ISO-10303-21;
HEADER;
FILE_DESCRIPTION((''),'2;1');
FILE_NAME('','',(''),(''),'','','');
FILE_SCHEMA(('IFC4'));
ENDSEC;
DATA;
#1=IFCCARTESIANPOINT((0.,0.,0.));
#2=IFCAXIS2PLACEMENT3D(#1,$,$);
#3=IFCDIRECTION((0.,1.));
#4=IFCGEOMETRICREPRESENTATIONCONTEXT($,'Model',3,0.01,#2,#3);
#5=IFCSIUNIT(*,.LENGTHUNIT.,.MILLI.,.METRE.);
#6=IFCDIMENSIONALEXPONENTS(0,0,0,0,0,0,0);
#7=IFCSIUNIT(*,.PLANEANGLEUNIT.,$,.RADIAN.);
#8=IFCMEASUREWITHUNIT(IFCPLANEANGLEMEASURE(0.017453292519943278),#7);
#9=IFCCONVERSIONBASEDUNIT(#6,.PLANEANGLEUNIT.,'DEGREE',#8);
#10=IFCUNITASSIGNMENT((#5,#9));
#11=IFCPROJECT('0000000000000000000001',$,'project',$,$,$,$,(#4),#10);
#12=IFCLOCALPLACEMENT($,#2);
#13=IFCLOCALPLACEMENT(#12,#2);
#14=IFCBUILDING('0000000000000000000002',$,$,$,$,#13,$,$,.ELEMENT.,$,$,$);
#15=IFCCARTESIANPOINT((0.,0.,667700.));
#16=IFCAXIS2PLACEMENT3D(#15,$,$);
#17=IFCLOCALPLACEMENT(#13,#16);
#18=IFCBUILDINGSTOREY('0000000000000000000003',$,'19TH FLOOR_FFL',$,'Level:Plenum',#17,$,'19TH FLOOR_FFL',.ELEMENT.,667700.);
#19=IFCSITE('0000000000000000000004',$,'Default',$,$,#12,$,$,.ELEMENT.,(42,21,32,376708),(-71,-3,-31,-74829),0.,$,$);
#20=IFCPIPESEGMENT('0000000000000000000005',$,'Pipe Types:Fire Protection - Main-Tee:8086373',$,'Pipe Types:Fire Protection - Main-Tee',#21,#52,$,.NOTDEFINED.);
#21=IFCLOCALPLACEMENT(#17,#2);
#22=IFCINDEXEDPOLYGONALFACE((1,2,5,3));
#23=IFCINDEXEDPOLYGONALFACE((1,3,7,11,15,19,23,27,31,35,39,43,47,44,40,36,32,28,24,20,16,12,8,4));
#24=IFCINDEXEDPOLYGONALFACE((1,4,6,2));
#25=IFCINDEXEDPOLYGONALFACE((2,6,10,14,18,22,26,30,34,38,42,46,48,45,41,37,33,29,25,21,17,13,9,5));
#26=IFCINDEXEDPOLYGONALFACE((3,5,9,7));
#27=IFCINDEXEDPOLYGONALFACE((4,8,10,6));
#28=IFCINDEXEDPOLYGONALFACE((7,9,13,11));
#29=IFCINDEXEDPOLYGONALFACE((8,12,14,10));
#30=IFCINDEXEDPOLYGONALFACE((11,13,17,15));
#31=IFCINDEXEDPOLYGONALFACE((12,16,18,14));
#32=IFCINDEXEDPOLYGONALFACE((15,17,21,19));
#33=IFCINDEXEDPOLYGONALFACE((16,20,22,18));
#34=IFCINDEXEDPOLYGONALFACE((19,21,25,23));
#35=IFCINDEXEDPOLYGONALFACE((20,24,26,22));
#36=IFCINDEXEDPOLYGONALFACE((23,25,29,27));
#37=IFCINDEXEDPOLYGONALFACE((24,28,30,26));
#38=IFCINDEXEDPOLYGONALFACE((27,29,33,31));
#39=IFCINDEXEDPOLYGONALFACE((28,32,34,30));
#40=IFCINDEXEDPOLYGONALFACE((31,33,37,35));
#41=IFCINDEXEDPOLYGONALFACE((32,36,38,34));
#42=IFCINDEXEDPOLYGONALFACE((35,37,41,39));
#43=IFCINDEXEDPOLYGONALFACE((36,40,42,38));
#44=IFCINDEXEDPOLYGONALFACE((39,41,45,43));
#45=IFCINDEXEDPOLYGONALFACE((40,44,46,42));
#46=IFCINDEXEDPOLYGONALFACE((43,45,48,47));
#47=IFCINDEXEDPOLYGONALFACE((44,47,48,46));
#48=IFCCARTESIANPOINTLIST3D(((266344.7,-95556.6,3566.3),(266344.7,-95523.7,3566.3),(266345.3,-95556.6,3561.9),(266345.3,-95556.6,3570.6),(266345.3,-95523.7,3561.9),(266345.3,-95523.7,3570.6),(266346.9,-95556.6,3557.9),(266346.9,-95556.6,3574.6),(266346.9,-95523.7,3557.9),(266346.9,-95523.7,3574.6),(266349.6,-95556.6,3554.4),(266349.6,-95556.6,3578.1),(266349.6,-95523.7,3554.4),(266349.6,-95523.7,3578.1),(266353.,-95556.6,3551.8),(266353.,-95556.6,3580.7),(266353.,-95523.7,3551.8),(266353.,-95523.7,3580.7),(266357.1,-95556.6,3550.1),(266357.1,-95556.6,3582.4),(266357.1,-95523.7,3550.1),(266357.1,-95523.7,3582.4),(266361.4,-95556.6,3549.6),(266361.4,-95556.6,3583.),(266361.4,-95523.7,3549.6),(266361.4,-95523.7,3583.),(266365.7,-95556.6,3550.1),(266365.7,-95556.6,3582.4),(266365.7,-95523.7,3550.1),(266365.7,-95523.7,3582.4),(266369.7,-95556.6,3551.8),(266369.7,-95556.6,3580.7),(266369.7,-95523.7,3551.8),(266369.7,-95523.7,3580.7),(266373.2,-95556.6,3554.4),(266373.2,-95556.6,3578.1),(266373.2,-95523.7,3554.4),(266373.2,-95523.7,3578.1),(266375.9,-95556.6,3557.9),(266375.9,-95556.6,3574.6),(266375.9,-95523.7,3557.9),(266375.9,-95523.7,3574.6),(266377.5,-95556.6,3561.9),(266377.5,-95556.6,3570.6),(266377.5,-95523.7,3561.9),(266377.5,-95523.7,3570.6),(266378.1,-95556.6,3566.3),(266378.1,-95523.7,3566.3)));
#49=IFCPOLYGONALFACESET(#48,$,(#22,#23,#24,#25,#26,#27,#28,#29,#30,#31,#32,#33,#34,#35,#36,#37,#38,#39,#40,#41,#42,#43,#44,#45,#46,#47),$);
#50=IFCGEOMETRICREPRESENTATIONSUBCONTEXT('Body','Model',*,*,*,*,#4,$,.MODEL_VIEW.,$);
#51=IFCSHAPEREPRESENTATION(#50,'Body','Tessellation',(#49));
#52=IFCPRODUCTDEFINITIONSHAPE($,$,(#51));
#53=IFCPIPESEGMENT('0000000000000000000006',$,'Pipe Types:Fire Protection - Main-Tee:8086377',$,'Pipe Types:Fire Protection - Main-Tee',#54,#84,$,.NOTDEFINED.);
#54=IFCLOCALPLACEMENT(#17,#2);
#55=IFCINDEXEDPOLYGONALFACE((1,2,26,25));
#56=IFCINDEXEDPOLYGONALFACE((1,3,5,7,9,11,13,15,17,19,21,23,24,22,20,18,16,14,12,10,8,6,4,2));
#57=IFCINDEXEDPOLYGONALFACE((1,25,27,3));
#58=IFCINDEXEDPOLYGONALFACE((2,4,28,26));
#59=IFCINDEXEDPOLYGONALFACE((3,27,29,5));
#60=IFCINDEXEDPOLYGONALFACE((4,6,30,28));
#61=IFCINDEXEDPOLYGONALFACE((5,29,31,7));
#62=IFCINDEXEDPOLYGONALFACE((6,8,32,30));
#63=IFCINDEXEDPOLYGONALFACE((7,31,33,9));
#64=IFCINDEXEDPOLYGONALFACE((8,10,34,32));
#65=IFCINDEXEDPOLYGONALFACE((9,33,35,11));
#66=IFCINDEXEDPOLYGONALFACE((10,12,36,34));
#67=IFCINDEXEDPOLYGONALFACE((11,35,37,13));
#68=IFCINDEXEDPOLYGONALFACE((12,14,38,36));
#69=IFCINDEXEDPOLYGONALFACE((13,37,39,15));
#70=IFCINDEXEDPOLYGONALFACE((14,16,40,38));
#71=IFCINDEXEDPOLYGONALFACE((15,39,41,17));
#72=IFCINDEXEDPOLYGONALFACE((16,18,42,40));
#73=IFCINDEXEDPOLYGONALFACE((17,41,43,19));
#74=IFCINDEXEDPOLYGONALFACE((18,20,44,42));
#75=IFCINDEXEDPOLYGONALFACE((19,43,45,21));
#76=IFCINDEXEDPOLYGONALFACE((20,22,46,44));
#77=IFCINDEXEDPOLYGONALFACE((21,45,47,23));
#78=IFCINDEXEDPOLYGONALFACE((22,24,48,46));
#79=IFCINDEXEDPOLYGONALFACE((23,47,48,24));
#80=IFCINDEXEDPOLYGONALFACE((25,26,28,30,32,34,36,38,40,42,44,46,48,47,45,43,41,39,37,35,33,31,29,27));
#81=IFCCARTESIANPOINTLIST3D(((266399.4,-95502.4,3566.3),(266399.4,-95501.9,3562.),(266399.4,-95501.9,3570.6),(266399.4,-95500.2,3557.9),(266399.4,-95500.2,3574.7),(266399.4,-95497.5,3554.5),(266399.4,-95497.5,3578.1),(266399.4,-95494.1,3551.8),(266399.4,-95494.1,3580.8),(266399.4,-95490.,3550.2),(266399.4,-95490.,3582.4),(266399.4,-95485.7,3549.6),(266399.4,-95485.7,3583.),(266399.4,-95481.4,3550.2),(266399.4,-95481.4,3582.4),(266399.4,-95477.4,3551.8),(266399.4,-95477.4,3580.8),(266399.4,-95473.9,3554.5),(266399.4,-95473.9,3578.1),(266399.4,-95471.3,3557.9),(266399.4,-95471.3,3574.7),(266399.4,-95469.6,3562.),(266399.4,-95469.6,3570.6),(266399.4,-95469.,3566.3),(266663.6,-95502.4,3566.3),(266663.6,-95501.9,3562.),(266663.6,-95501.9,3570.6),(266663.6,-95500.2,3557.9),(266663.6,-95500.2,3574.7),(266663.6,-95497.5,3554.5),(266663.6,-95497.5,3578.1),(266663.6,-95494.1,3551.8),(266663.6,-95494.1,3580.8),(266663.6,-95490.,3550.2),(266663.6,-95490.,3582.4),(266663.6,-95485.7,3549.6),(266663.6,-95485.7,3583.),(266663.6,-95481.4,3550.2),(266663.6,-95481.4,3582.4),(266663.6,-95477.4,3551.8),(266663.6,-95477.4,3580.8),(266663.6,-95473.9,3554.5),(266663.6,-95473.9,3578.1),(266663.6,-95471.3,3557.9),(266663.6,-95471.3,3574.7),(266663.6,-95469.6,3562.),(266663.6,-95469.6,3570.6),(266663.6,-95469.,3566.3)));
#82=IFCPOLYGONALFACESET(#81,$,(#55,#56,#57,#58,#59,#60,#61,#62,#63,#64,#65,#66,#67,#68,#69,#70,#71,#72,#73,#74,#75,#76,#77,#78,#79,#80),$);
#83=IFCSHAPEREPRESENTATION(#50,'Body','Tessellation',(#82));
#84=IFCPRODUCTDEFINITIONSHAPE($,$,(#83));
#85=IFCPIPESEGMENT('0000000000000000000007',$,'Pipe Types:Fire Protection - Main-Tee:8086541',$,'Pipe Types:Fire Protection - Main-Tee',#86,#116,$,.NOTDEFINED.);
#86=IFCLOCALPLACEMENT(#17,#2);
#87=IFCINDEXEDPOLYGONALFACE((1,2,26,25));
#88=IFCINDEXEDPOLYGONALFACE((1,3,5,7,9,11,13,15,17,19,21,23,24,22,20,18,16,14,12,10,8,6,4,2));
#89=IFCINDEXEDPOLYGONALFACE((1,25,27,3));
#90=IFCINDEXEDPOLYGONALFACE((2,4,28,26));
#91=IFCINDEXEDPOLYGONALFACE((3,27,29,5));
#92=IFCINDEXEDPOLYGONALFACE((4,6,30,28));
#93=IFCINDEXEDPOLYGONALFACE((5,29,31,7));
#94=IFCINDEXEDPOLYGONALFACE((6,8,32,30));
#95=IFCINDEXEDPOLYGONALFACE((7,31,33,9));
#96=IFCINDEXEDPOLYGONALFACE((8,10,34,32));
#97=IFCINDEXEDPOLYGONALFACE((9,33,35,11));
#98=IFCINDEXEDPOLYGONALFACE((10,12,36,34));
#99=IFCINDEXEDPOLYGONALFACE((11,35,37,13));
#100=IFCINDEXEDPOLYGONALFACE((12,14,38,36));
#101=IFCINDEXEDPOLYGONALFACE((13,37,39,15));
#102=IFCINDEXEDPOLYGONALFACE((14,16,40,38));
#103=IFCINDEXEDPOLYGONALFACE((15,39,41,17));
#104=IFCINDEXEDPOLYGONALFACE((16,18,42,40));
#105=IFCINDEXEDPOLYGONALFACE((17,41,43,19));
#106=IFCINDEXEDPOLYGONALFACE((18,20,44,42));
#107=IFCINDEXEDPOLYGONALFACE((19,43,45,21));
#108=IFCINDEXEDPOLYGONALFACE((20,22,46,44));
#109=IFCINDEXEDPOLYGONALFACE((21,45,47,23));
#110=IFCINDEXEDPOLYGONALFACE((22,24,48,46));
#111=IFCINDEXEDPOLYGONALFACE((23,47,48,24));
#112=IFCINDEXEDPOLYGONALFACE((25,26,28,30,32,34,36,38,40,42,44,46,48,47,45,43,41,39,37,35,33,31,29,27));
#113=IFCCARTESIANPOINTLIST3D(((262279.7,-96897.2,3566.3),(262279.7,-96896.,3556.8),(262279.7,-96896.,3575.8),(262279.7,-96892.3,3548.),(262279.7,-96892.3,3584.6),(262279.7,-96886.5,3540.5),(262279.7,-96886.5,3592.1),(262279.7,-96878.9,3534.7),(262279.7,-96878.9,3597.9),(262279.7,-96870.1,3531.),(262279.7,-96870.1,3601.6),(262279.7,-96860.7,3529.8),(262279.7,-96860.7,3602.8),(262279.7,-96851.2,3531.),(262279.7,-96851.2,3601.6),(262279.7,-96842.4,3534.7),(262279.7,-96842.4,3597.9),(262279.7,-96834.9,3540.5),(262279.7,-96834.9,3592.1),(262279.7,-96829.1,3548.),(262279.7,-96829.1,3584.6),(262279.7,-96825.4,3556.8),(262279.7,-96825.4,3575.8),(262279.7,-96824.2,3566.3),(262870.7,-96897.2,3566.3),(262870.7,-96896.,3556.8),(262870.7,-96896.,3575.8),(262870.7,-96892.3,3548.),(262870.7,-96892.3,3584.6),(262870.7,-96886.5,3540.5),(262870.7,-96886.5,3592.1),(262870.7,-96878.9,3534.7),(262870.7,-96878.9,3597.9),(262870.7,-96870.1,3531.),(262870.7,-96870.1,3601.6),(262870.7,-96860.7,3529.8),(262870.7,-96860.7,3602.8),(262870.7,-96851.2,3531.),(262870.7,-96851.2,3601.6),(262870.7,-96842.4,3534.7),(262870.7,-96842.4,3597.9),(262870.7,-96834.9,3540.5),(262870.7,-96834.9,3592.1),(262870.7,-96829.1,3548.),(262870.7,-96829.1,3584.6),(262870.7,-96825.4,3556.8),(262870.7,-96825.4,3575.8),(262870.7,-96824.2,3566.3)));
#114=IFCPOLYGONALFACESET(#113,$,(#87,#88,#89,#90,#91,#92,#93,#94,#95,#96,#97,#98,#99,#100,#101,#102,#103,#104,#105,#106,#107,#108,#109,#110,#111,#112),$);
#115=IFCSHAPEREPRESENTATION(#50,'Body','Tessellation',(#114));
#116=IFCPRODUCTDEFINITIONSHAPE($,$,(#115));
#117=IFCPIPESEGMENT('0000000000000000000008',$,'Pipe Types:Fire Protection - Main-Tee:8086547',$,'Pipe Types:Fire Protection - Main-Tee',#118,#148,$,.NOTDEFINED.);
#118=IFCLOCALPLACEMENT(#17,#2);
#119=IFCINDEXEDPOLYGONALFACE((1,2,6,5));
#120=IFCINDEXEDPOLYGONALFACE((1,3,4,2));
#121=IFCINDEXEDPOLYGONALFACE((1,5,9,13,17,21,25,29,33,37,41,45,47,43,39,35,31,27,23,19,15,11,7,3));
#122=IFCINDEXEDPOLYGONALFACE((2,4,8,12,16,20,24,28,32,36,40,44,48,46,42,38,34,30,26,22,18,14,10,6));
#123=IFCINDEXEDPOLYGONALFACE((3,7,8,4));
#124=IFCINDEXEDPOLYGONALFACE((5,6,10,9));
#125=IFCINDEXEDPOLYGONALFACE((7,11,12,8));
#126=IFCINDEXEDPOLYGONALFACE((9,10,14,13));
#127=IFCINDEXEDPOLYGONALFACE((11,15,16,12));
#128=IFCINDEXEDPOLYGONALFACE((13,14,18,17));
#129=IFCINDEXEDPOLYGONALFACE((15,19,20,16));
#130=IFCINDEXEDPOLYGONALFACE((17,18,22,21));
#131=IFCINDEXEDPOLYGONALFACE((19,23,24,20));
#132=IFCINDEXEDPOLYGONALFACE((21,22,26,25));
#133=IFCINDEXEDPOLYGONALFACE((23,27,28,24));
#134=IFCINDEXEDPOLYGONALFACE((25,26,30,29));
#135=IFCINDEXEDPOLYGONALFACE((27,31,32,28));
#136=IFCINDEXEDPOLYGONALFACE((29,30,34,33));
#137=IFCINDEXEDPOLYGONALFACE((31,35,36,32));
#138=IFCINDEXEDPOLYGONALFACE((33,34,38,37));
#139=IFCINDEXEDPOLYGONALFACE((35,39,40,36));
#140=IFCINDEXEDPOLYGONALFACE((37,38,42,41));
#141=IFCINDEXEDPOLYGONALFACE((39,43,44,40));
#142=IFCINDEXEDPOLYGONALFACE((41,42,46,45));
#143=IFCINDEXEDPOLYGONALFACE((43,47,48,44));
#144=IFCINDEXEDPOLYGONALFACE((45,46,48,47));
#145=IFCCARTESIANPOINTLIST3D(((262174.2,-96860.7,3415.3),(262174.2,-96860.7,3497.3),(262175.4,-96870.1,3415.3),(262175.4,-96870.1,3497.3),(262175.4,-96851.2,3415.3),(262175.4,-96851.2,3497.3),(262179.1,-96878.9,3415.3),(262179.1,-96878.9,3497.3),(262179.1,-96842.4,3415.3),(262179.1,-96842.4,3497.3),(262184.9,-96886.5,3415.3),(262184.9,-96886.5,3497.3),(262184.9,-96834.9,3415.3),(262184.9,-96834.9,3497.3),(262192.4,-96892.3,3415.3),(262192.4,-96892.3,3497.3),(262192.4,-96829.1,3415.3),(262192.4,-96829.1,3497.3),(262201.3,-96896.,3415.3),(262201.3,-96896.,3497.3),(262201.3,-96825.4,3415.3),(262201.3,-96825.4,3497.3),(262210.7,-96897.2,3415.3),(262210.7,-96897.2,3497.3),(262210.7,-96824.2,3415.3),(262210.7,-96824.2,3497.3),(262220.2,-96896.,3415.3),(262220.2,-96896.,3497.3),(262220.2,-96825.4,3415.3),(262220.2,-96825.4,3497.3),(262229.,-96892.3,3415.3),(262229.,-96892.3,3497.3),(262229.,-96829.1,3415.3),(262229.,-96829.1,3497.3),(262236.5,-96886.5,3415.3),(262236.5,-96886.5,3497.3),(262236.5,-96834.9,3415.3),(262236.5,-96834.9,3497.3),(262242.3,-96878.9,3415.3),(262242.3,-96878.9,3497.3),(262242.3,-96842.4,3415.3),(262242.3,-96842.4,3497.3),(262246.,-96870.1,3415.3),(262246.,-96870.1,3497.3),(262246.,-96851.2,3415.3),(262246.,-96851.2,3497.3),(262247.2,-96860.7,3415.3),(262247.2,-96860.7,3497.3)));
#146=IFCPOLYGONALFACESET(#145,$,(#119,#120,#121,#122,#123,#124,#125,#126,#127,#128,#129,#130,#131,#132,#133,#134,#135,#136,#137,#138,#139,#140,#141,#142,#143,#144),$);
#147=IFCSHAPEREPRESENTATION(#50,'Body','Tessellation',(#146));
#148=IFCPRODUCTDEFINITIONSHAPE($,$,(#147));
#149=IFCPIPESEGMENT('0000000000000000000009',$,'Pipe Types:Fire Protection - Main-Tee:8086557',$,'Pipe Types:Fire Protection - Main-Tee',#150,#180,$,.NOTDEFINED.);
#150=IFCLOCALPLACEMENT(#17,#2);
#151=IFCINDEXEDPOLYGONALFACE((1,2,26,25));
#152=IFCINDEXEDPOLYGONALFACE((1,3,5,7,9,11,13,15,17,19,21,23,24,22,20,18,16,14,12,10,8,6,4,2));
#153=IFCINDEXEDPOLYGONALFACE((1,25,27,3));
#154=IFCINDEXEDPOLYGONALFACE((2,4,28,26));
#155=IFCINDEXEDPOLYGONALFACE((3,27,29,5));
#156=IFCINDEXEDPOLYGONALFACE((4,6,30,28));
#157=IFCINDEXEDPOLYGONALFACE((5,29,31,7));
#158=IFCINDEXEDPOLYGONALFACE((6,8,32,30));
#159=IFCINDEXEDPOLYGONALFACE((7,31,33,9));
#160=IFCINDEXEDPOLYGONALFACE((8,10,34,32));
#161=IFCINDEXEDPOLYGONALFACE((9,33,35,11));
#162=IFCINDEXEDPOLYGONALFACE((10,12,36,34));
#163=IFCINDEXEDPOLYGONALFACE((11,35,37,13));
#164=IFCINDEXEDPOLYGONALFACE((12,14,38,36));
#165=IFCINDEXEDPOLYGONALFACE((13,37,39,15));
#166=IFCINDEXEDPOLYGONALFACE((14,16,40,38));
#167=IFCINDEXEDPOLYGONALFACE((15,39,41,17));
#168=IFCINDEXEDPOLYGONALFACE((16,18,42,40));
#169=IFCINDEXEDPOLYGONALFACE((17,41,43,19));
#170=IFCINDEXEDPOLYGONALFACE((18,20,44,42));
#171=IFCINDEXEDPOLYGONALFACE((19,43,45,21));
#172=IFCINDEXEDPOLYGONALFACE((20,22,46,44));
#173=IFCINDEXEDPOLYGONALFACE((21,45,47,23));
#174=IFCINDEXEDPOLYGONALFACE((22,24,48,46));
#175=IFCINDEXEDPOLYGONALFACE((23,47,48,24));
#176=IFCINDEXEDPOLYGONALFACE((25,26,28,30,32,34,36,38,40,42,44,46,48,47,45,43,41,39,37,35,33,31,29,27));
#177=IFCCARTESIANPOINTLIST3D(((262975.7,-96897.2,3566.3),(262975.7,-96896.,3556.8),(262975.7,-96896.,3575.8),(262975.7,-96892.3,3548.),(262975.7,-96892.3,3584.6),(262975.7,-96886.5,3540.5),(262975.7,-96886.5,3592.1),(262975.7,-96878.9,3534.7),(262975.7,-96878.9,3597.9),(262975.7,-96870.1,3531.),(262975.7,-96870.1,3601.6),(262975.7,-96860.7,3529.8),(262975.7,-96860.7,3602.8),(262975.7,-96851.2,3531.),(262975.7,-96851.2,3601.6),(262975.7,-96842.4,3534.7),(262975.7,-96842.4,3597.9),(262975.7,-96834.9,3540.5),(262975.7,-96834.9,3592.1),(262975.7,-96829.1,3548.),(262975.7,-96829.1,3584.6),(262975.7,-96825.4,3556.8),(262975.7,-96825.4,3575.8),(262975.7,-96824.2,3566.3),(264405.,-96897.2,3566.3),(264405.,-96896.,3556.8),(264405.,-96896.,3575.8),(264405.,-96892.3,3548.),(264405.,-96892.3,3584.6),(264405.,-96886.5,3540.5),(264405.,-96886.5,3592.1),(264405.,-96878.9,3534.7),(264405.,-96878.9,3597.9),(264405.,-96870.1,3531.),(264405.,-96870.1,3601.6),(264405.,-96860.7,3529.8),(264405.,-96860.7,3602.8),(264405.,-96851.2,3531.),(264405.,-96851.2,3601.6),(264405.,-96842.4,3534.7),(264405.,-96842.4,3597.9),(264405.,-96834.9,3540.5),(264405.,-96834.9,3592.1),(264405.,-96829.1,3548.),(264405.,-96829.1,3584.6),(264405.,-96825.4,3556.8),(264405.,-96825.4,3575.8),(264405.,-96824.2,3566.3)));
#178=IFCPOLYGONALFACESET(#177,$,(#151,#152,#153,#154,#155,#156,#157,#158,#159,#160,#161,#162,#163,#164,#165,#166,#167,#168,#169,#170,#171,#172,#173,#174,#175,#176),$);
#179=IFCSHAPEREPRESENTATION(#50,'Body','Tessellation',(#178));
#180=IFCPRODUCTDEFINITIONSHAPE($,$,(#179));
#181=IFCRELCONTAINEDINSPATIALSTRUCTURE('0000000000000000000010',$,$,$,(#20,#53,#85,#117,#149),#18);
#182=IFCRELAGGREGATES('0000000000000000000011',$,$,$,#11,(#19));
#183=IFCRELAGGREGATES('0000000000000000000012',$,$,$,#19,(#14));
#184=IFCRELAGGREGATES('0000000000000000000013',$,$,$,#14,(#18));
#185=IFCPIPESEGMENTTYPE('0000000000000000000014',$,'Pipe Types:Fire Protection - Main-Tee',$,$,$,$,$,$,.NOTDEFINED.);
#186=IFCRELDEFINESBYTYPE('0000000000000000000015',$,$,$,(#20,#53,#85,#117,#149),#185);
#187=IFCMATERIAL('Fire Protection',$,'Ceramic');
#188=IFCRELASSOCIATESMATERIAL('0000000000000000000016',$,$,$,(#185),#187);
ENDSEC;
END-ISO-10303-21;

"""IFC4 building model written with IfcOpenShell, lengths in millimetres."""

from ifc_helpers import new_model, entity, si_unit, converted_unit, direction, frame, origin, place, context, subcontext, project, spatial, arc, indexed_curve, outline, extrude, material, type_object, element, save


model = new_model("IFC4")

# Units and contexts
model_context = context("Model", 3, precision=0.01, world=origin(), true_north=direction((0.0, 1.0)))
body_context = subcontext(model_context, "Body", "Model", "MODEL_VIEW")
ifc_project = project(units=[si_unit("LENGTHUNIT", "METRE", prefix="MILLI"), converted_unit("PLANEANGLEUNIT", "DEGREE", entity("IfcPlaneAngleMeasure", 0.017453292519943278), si_unit("PLANEANGLEUNIT", "RADIAN"), dimensions=[0, 0, 0, 0, 0, 0, 0])], contexts=[model_context])

# Site, building, storey
site_placement = place(None, origin())
site = spatial("IfcSite", under=ifc_project, at=site_placement, Name="Default", CompositionType="ELEMENT", RefLatitude=(42, 21, 32, 376708), RefLongitude=(-71, -3, -31, -74829), RefElevation=0.0)
building_placement = place(site_placement, origin())
building = spatial("IfcBuilding", under=site, at=building_placement, CompositionType="ELEMENT")
storey_placement = place(building_placement, frame((0.0, 0.0, 667700.0)))
storey = spatial("IfcBuildingStorey", under=building, at=storey_placement, Name="19TH FLOOR_FFL", ObjectType="Level:Plenum", LongName="19TH FLOOR_FFL", CompositionType="ELEMENT", Elevation=667700.0)

# Pipe segments
ifc_material = material(Name="Fire Protection", Category="Ceramic")
pipe_segment_type = type_object("IfcPipeSegmentType", Name="Pipe Types:Fire Protection - Main-Tee", PredefinedType="NOTDEFINED", material=ifc_material)
pipe_segment_1_placement = place(storey_placement, origin())
element("IfcPipeSegment", 1, at=pipe_segment_1_placement, inside=storey, type_object=pipe_segment_type, Name="Pipe Types:Fire Protection - Main-Tee:8086373", ObjectType="Pipe Types:Fire Protection - Main-Tee", PredefinedType="NOTDEFINED", context=body_context, shape_type="SweptSolid", body=[
    extrude(outline(indexed_curve([(16.7, 0.0), (11.8, 11.8), (0.0, 16.7), (-11.8, 11.8), (-16.7, 0.0), (-11.8, -11.8), (0.0, -16.7), (11.8, -11.8)], segments=[arc(1, 2, 3), arc(3, 4, 5), arc(5, 6, 7), arc(7, 8, 1)], self_intersect=False)), frame((266361.4, -95556.6, 3566.3), z_axis=(0.0, 1.0, -0.000117), x_axis=(1.0, 0.0, 0.0)), (0.0, 0.0, 1.0), 32.9),
])
pipe_segment_2_placement = place(storey_placement, origin())
element("IfcPipeSegment", 2, at=pipe_segment_2_placement, inside=storey, type_object=pipe_segment_type, Name="Pipe Types:Fire Protection - Main-Tee:8086377", ObjectType="Pipe Types:Fire Protection - Main-Tee", PredefinedType="NOTDEFINED", context=body_context, shape_type="SweptSolid", body=[
    extrude(outline(indexed_curve([(16.7, 0.0), (11.8, 11.8), (0.0, 16.7), (-11.8, 11.8), (-16.7, 0.0), (-11.8, -11.8), (0.0, -16.7), (11.8, -11.8)], segments=[arc(1, 2, 3), arc(3, 4, 5), arc(5, 6, 7), arc(7, 8, 1)], self_intersect=False)), frame((266399.4, -95485.7, 3566.3), z_axis=(1.0, 0.0, 0.0), x_axis=(0.0, -1.0, 0.0)), (0.0, 0.0, 1.0), 264.2),
])
pipe_segment_3_placement = place(storey_placement, origin())
element("IfcPipeSegment", 3, at=pipe_segment_3_placement, inside=storey, type_object=pipe_segment_type, Name="Pipe Types:Fire Protection - Main-Tee:8086541", ObjectType="Pipe Types:Fire Protection - Main-Tee", PredefinedType="NOTDEFINED", context=body_context, shape_type="SweptSolid", body=[
    extrude(outline(indexed_curve([(36.5, 0.0), (25.8, 25.8), (0.0, 36.5), (-25.8, 25.8), (-36.5, 0.0), (-25.8, -25.8), (0.0, -36.5), (25.8, -25.8)], segments=[arc(1, 2, 3), arc(3, 4, 5), arc(5, 6, 7), arc(7, 8, 1)], self_intersect=False)), frame((262279.7, -96860.7, 3566.3), z_axis=(1.0, 0.0, 0.0), x_axis=(0.0, 1.0, 0.0)), (0.0, 0.0, 1.0), 591.0),
])
pipe_segment_4_placement = place(storey_placement, origin())
element("IfcPipeSegment", 4, at=pipe_segment_4_placement, inside=storey, type_object=pipe_segment_type, Name="Pipe Types:Fire Protection - Main-Tee:8086547", ObjectType="Pipe Types:Fire Protection - Main-Tee", PredefinedType="NOTDEFINED", context=body_context, shape_type="SweptSolid", body=[
    extrude(outline(indexed_curve([(36.5, 0.0), (25.8, 25.8), (0.0, 36.5), (-25.8, 25.8), (-36.5, 0.0), (-25.8, -25.8), (0.0, -36.5), (25.8, -25.8)], segments=[arc(1, 2, 3), arc(3, 4, 5), arc(5, 6, 7), arc(7, 8, 1)], self_intersect=False)), frame((262210.7, -96860.7, 3415.3)), (0.0, 0.0, 1.0), 82.0),
])
pipe_segment_5_placement = place(storey_placement, origin())
element("IfcPipeSegment", 5, at=pipe_segment_5_placement, inside=storey, type_object=pipe_segment_type, Name="Pipe Types:Fire Protection - Main-Tee:8086557", ObjectType="Pipe Types:Fire Protection - Main-Tee", PredefinedType="NOTDEFINED", context=body_context, shape_type="SweptSolid", body=[
    extrude(outline(indexed_curve([(36.5, 0.0), (25.8, 25.8), (0.0, 36.5), (-25.8, 25.8), (-36.5, 0.0), (-25.8, -25.8), (0.0, -36.5), (25.8, -25.8)], segments=[arc(1, 2, 3), arc(3, 4, 5), arc(5, 6, 7), arc(7, 8, 1)], self_intersect=False)), frame((262975.7, -96860.7, 3566.3), z_axis=(1.0, 0.0, 0.0), x_axis=(0.0, 1.0, 0.0)), (0.0, 0.0, 1.0), 1429.3),
])

save(model, "model.ifc")
